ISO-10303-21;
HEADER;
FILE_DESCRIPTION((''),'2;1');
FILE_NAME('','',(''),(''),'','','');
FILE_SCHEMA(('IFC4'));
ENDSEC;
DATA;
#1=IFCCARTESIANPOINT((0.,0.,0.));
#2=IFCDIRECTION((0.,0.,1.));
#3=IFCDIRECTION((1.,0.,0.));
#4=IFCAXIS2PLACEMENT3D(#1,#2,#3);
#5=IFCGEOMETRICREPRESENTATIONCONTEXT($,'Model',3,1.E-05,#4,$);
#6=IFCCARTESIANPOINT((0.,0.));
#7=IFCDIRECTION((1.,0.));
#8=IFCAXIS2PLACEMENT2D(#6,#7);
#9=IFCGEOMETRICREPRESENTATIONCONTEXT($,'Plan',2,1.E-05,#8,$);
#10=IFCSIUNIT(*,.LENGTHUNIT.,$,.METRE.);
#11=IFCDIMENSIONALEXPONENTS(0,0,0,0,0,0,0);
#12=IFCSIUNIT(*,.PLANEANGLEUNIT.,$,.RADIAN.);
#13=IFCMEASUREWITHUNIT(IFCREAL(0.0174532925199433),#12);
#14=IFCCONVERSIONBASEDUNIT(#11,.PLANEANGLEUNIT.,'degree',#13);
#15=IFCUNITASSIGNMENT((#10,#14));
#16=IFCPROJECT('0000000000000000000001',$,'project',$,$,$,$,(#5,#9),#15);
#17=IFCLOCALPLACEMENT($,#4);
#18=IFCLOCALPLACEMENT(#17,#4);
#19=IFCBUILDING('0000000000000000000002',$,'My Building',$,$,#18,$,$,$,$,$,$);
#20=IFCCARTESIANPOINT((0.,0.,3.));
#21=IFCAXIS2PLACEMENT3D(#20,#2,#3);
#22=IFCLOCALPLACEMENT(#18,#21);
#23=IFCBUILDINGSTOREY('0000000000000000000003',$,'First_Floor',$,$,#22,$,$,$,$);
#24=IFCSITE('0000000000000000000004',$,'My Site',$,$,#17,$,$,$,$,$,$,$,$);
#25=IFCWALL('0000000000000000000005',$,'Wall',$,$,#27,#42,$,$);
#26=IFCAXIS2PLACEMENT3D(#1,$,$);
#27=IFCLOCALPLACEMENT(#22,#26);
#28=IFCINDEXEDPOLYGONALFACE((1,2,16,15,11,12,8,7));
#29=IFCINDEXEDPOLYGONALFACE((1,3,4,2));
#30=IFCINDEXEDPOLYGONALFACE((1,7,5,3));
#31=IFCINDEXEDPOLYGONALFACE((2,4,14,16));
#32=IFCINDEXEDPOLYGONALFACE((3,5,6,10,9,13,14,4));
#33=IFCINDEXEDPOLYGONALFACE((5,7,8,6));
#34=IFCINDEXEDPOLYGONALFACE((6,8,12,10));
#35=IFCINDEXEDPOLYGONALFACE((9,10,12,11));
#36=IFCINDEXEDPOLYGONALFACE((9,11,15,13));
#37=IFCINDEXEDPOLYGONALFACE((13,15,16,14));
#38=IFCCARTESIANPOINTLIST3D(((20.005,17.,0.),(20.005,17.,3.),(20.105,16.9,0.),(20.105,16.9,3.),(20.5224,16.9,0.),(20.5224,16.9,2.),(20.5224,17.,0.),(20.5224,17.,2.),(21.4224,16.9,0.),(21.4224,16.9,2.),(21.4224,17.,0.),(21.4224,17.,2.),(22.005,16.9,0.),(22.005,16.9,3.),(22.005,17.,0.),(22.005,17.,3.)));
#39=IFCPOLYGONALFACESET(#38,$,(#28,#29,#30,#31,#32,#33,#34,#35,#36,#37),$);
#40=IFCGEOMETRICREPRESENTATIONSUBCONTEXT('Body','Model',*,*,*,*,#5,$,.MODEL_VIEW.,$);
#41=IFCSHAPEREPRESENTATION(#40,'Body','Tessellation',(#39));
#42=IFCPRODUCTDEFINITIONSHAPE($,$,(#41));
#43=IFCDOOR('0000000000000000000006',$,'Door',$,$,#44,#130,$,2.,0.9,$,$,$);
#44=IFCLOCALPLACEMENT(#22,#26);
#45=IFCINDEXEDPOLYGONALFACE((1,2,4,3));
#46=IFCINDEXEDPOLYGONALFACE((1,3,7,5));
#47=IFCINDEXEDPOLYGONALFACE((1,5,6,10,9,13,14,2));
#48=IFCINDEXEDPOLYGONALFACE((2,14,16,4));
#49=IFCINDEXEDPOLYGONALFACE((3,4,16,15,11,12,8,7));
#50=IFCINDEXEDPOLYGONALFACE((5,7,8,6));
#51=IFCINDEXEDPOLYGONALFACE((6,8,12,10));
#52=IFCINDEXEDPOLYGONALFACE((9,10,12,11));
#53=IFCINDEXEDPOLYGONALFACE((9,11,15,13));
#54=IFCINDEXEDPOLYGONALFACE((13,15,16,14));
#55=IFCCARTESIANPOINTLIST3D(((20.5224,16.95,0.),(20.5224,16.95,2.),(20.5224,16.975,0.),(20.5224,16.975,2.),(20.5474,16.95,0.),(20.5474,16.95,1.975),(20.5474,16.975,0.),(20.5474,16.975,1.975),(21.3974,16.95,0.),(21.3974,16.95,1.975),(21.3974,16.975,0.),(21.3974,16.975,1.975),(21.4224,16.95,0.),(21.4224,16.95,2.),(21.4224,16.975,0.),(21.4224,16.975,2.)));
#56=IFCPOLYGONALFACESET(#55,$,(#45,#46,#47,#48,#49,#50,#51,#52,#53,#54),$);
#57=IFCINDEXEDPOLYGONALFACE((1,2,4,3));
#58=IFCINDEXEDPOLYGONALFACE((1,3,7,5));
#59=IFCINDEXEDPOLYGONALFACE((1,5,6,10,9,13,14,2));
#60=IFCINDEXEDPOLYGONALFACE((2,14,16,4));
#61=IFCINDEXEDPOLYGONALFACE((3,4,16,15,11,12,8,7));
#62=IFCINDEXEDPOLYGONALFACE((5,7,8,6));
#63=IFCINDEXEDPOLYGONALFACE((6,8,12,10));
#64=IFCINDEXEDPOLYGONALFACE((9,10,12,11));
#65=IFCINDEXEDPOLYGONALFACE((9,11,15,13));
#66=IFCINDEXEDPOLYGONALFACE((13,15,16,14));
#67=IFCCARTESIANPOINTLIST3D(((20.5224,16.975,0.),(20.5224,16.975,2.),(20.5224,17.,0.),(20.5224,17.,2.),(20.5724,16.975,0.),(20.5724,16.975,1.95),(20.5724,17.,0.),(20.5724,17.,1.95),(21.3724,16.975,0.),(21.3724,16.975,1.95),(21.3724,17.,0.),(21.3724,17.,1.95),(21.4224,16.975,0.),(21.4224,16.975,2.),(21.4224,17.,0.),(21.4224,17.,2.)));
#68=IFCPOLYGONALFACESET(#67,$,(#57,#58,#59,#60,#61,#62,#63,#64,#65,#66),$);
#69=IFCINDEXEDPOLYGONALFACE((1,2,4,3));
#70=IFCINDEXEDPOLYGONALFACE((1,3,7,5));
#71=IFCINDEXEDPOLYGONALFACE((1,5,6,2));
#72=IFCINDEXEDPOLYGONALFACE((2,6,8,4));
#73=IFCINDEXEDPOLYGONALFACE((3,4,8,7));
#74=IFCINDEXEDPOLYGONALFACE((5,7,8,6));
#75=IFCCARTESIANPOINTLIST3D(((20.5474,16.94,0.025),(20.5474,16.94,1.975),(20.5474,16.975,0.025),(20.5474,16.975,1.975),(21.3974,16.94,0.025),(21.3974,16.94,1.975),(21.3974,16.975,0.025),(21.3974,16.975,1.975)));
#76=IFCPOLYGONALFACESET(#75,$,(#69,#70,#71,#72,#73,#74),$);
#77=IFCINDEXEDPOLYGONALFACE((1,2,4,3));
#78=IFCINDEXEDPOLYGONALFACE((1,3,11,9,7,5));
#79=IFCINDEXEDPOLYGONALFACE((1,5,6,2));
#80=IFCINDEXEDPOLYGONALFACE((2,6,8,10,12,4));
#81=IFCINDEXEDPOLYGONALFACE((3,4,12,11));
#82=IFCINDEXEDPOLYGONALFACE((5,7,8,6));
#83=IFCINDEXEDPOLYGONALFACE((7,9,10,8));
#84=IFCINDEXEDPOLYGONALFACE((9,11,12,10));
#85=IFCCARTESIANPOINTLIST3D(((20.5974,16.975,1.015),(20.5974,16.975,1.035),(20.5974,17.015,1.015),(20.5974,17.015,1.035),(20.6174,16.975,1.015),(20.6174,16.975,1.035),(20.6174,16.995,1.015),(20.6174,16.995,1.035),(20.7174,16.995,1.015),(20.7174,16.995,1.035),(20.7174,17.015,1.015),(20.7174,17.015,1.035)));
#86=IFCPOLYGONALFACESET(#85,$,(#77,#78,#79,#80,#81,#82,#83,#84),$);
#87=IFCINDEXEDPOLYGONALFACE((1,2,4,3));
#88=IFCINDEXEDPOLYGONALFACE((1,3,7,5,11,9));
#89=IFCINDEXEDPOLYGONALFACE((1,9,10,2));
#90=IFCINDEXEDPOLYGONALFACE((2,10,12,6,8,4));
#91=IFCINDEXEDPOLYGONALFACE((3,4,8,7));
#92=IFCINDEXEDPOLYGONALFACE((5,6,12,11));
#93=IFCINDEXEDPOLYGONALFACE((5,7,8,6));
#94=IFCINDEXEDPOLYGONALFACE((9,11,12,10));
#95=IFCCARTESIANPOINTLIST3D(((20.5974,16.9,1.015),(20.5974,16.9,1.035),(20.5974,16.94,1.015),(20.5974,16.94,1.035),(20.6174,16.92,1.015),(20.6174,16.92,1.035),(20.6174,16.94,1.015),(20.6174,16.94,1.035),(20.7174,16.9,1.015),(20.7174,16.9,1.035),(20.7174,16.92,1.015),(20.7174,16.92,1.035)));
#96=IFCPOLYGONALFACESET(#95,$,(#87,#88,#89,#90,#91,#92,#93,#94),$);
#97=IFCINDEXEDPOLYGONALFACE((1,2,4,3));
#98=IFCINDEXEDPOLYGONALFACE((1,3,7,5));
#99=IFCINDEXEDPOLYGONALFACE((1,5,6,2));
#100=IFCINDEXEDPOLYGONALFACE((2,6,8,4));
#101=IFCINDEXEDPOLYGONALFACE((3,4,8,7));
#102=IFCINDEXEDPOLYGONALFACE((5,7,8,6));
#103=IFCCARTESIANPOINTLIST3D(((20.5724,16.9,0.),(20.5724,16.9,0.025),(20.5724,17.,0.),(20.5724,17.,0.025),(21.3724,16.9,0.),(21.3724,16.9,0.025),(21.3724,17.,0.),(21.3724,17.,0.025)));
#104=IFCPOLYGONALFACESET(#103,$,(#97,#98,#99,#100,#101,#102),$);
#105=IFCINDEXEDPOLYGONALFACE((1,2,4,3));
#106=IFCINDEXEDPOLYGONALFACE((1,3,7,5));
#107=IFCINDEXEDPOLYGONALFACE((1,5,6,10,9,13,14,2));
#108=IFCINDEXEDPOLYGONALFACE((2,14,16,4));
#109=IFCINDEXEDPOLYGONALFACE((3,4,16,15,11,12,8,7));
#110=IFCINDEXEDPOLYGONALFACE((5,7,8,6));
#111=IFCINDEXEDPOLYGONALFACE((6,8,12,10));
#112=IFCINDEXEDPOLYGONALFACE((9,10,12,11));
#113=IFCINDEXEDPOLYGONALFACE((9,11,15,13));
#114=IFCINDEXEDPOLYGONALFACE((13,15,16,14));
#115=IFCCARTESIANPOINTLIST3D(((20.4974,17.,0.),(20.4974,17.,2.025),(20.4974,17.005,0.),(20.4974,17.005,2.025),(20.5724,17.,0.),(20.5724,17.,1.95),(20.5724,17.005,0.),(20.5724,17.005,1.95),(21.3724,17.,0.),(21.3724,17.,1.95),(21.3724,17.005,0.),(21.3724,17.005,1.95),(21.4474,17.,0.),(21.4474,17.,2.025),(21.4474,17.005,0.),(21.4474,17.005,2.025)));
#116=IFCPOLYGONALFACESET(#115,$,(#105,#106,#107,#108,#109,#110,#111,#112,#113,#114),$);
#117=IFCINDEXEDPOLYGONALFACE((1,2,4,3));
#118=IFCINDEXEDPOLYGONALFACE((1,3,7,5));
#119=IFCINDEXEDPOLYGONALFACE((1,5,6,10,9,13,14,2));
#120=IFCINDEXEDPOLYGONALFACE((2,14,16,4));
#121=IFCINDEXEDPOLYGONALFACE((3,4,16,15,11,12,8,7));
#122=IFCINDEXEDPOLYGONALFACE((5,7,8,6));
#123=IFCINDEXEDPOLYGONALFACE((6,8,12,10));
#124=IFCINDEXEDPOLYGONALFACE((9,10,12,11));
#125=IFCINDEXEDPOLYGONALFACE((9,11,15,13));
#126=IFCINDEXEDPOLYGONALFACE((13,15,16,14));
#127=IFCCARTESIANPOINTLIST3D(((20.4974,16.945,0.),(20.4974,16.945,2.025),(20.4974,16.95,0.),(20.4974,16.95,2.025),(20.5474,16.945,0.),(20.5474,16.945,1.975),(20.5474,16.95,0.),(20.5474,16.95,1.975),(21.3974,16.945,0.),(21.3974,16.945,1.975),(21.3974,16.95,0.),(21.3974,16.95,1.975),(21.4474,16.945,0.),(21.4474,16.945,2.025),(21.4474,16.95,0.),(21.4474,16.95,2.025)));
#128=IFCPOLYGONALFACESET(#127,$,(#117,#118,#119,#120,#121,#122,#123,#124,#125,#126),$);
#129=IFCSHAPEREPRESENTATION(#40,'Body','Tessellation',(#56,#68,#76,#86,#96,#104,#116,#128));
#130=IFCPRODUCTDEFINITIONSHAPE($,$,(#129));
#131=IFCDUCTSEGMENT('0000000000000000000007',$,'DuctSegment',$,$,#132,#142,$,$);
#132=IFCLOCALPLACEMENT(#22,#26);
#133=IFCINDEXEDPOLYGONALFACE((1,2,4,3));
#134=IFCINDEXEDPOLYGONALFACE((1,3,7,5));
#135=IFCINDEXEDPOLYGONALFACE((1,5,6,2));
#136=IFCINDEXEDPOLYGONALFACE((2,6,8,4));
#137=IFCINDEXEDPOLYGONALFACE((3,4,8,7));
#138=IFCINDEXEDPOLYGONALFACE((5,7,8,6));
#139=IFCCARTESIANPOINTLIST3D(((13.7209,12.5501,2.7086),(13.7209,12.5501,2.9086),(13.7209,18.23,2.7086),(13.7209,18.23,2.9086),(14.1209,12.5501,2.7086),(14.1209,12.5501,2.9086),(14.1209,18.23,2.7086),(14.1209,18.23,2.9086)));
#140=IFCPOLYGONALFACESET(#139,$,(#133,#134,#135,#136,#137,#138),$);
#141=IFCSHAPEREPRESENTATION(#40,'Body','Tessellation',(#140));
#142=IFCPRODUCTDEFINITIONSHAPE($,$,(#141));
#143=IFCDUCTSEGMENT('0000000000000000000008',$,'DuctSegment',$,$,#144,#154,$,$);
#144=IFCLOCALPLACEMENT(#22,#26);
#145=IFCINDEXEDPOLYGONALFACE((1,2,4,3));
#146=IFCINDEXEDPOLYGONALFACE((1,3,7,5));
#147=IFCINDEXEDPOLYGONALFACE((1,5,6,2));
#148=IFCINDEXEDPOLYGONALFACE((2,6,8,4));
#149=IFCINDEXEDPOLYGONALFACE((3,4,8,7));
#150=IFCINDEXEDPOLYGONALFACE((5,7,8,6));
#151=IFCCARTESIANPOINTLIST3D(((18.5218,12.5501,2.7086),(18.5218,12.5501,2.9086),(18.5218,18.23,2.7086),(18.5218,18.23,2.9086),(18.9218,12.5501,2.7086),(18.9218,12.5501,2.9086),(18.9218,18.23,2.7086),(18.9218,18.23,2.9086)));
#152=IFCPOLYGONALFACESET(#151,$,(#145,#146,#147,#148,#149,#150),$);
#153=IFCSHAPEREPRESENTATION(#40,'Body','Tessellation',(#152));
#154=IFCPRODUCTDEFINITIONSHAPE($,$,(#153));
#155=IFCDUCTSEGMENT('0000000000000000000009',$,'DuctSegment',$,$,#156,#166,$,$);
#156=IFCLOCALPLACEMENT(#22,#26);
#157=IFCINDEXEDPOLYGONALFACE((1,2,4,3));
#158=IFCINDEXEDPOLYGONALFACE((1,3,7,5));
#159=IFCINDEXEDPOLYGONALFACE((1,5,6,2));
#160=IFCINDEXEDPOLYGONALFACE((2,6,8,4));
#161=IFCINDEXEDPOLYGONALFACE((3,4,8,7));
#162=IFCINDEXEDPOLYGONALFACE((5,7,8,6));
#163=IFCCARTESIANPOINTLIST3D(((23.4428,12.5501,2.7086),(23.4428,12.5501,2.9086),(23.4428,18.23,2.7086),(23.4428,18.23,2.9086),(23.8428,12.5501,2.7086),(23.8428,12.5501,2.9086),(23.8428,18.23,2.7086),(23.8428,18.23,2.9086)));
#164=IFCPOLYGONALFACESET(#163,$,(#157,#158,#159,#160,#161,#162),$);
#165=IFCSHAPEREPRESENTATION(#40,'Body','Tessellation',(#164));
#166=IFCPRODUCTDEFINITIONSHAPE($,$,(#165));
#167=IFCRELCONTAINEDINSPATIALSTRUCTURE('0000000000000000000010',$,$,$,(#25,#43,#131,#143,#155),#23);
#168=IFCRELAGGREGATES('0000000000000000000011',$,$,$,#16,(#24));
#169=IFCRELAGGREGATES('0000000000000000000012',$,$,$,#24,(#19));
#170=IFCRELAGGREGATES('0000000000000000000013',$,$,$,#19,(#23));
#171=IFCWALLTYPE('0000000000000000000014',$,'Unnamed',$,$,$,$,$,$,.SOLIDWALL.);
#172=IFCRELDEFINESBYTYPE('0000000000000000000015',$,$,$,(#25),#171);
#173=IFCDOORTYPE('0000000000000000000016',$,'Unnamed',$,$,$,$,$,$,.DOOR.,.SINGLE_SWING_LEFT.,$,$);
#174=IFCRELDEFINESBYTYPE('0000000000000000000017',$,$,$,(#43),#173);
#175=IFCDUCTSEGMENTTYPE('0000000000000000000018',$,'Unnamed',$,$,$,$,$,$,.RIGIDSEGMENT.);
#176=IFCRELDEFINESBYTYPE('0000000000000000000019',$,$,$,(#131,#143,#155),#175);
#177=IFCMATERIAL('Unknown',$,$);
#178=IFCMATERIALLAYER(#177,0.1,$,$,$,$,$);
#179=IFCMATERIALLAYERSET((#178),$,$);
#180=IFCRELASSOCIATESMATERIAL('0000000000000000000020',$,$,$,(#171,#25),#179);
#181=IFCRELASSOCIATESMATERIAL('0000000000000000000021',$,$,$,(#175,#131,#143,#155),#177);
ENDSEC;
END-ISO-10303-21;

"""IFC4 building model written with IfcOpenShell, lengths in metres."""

from ifc_helpers import new_model, entity, si_unit, converted_unit, frame, origin_with_axes, origin_2d_with_axis, place, context, subcontext, project, spatial, line, indexed_curve, rectangle, outline, extrude, shape, source, transform, mapped, material, layer, layer_set, layer_usage, material_profile, profile_set, profile_usage, type_object, type_shapes, element, fill, save


model = new_model("IFC4")

# Units and contexts
model_context = context("Model", 3, precision=1e-05, world=origin_with_axes())
plan_context = context("Plan", 2, precision=1e-05, world=origin_2d_with_axis())
body_context_1 = subcontext(model_context, "Body", "Model", "MODEL_VIEW")
body_context_2 = subcontext(plan_context, "Body", "Plan", "PLAN_VIEW")
ifc_project = project(units=[si_unit("LENGTHUNIT", "METRE"), converted_unit("PLANEANGLEUNIT", "degree", entity("IfcReal", 0.0174532925199433), si_unit("PLANEANGLEUNIT", "RADIAN"), dimensions=[0, 0, 0, 0, 0, 0, 0])], contexts=[model_context, plan_context])

# Site, building, storey
site_placement = place(None, origin_with_axes())
site = spatial("IfcSite", under=ifc_project, at=site_placement, Name="My Site")
building_placement = place(site_placement, origin_with_axes())
building = spatial("IfcBuilding", under=site, at=building_placement, Name="My Building")
storey_placement = place(building_placement, frame((0.0, 0.0, 3.0), z_axis=(0.0, 0.0, 1.0), x_axis=(1.0, 0.0, 0.0)))
storey = spatial("IfcBuildingStorey", under=building, at=storey_placement, Name="First_Floor")

# Shared definitions
ifc_material = material(Name="Unknown")
ifc_layer = layer(ifc_material, 0.1)
ifc_layer_set = layer_set([ifc_layer])
wall_type = type_object("IfcWallType", Name="Unnamed", PredefinedType="SOLIDWALL", material=ifc_layer_set)
shared_shape_1 = source(origin_with_axes(), body_context_1, "Body", "SweptSolid", [
    extrude(outline(indexed_curve([(0.0, 0.0), (0.9, 0.0), (0.9, 2.0), (0.0, 2.0)], segments=[line(1, 2, 3, 4, 1)])), frame((0.0, -0.6, 0.0), z_axis=(0.0, -1.0, 0.0), x_axis=(1.0, 0.0, 0.0)), (0.0, 0.0, -1.0), 1.2),
])
door_type = type_object("IfcDoorType", Name="Unnamed", OperationType="SINGLE_SWING_LEFT", PredefinedType="DOOR")
shared_shape_2 = source(origin_with_axes(), body_context_1, "Body", "SweptSolid", [
    extrude(outline(indexed_curve([(0.0, 0.0), (0.0, 2.0), (0.9, 2.0), (0.9, 0.0), (0.875, 0.0), (0.875, 1.975), (0.025, 1.975), (0.025, 0.0)], segments=[line(1, 2, 3, 4, 5, 6, 7, 8, 1)])), frame((0.0, 0.025, 0.0), z_axis=(0.0, -1.0, 0.0), x_axis=(1.0, 0.0, 0.0)), (0.0, 0.0, -1.0), 0.025),
    extrude(outline(indexed_curve([(0.0, 0.0), (0.0, 2.0), (0.9, 2.0), (0.9, 0.0), (0.85, 0.0), (0.85, 1.95), (0.05, 1.95), (0.05, 0.0)], segments=[line(1, 2, 3, 4, 5, 6, 7, 8, 1)])), frame((0.0, 0.0, 0.0), z_axis=(0.0, -1.0, 0.0), x_axis=(1.0, 0.0, 0.0)), (0.0, 0.0, -1.0), 0.025),
    extrude(outline(indexed_curve([(0.0, 0.0), (0.85, 0.0), (0.85, 0.035), (0.0, 0.035)], segments=[line(1, 2, 3, 4, 1)])), frame((0.025, 0.025, 0.025), z_axis=(0.0, 0.0, 1.0), x_axis=(1.0, 0.0, 0.0)), (0.0, 0.0, 1.0), 1.95),
    extrude(outline(indexed_curve([(0.0, 0.0), (0.0, -0.04), (-0.12, -0.04), (-0.12, -0.02), (-0.02, -0.02), (-0.02, 0.0)], segments=[line(1, 2, 3, 4, 5, 6, 1)])), frame((0.825, 0.025, 1.015), z_axis=(0.0, 0.0, 1.0), x_axis=(1.0, 0.0, 0.0)), (0.0, 0.0, 1.0), 0.02),
    extrude(outline(indexed_curve([(0.0, 0.0), (0.0, 0.04), (-0.12, 0.04), (-0.12, 0.02), (-0.02, 0.02), (-0.02, 0.0)], segments=[line(1, 2, 3, 4, 5, 6, 1)])), frame((0.825, 0.06, 1.015), z_axis=(0.0, 0.0, 1.0), x_axis=(1.0, 0.0, 0.0)), (0.0, 0.0, 1.0), 0.02),
    extrude(outline(indexed_curve([(0.0, 0.0), (0.8, 0.0), (0.8, 0.1), (0.0, 0.1)], segments=[line(1, 2, 3, 4, 1)])), frame((0.05, 0.0, 0.0), z_axis=(0.0, 0.0, 1.0), x_axis=(1.0, 0.0, 0.0)), (0.0, 0.0, 1.0), 0.025),
    extrude(outline(indexed_curve([(0.0, 0.0), (0.0, 2.025), (0.95, 2.025), (0.95, 0.0), (0.875, 0.0), (0.875, 1.95), (0.075, 1.95), (0.075, 0.0)], segments=[line(1, 2, 3, 4, 5, 6, 7, 8, 1)])), frame((-0.025, -0.005, 0.0), z_axis=(0.0, -1.0, 0.0), x_axis=(1.0, 0.0, 0.0)), (0.0, 0.0, -1.0), 0.005),
    extrude(outline(indexed_curve([(0.0, 0.0), (0.0, 2.025), (0.95, 2.025), (0.95, 0.0), (0.9, 0.0), (0.9, 1.975), (0.05, 1.975), (0.05, 0.0)], segments=[line(1, 2, 3, 4, 5, 6, 7, 8, 1)])), frame((-0.025, 0.05, 0.0), z_axis=(0.0, -1.0, 0.0), x_axis=(1.0, 0.0, 0.0)), (0.0, 0.0, -1.0), 0.005),
])
shared_shape_3 = source(origin_with_axes(), body_context_2, "Body", "Curve2D", [
    entity("IfcIndexedPolyCurve", entity("IfcCartesianPointList2D", [[0.0, 0.0], [0.0, 0.05], [0.025, 0.05], [0.025, 0.025], [0.05, 0.025], [0.05, 0.0]]), [entity("IfcLineIndex", [1, 2, 3, 4, 5, 6, 1])]),
    entity("IfcIndexedPolyCurve", entity("IfcCartesianPointList2D", [[0.9, 0.0], [0.9, 0.05], [0.875, 0.05], [0.875, 0.025], [0.85, 0.025], [0.85, 0.0]]), [entity("IfcLineIndex", [1, 2, 3, 4, 5, 6, 1])]),
    entity("IfcTrimmedCurve", entity("IfcEllipse", entity("IfcAxis2Placement2D", entity("IfcCartesianPoint", [0.06, 0.05]), entity("IfcDirection", [1.0, 0.0])), 0.815, 0.85), [entity("IfcCartesianPoint", [0.875, 0.05])], [entity("IfcCartesianPoint", [0.06, 0.9])], True, "CARTESIAN"),
    entity("IfcIndexedPolyCurve", entity("IfcCartesianPointList2D", [[0.025, 0.05], [0.06, 0.05], [0.06, 0.9], [0.025, 0.9]]), [entity("IfcLineIndex", [1, 2, 3, 4, 1])]),
])
type_shapes(door_type, [shared_shape_2, shared_shape_3])

# Wall, opening, door
ifc_layer_usage_1 = layer_usage(ifc_layer_set, "AXIS2", "POSITIVE", 0.0)
wall_1_placement = place(storey_placement, frame((22.005, 17.0, 0.0), z_axis=(0.0, 0.0, 1.0), x_axis=(-1.0, 0.0, 0.0)))
wall_1 = element("IfcWall", 1, at=wall_1_placement, inside=storey, type_object=wall_type, material=ifc_layer_usage_1, Name="Wall", context=body_context_1, shape_type="SweptSolid", body=[
    extrude(outline(indexed_curve([(0.0, 0.0), (0.0, 0.1), (1.9, 0.1), (2.0, 0.0)], segments=[line(1, 2, 3, 4, 1)])), origin_with_axes(), (0.0, 0.0, 1.0), 3.0),
])
opening_1_placement = place(wall_1_placement, frame((0.5826, 0.0, 0.0), z_axis=(0.0, 0.0, 1.0), x_axis=(1.0, 0.0, 0.0)))
opening_1 = element("IfcOpeningElement", 2, at=opening_1_placement, cuts=wall_1, PredefinedType="OPENING", context=body_context_1, shape_type="MappedRepresentation", body=[
    mapped(shared_shape_1, transform((0.0, 0.0, 0.0), x_axis=(1.0, 0.0, 0.0), y_axis=(0.0, 1.0, 0.0), z_axis=(0.0, 0.0, 1.0), scale=1.0)),
])
door_1_placement = place(opening_1_placement, origin_with_axes())
door_1 = element("IfcDoor", 3, at=door_1_placement, inside=storey, type_object=door_type, Name="Door", OverallHeight=2.0, OverallWidth=0.9, shapes=[
    shape(body_context_1, "Body", "MappedRepresentation", [mapped(shared_shape_2, transform((0.0, 0.0, 0.0), x_axis=(1.0, 0.0, 0.0), y_axis=(0.0, 1.0, 0.0), z_axis=(0.0, 0.0, 1.0), scale=1.0))]),
    shape(body_context_2, "Body", "MappedRepresentation", [mapped(shared_shape_3, transform((0.0, 0.0, 0.0), x_axis=(1.0, 0.0, 0.0), y_axis=(0.0, 1.0, 0.0), z_axis=(0.0, 0.0, 1.0), scale=1.0))]),
])
fill(opening_1, door_1)

# Duct segments
ifc_material_profile_1 = material_profile(ifc_material, rectangle(XDim=0.4, YDim=0.2))
ifc_profile_set_1 = profile_set([ifc_material_profile_1])
ifc_profile_usage_1 = profile_usage(ifc_profile_set_1, cardinal=5)
duct_segment_type = type_object("IfcDuctSegmentType", Name="Unnamed", PredefinedType="RIGIDSEGMENT", material=ifc_profile_set_1)
duct_segment_1_placement = place(storey_placement, frame((13.9209, 12.5501, 2.8086), z_axis=(0.0, 1.0, 0.0), x_axis=(-1.0, 0.0, 0.0)))
element("IfcDuctSegment", 4, at=duct_segment_1_placement, inside=storey, type_object=duct_segment_type, material=ifc_profile_usage_1, Name="DuctSegment", context=body_context_1, shape_type="SweptSolid", body=[
    extrude(rectangle(XDim=0.4, YDim=0.2), origin_with_axes(), (0.0, 0.0, 1.0), 5.6799),
])
ifc_profile_usage_2 = profile_usage(ifc_profile_set_1, cardinal=5)
duct_segment_2_placement = place(storey_placement, frame((18.7218, 12.5501, 2.8086), z_axis=(0.0, 1.0, 0.0), x_axis=(-1.0, 0.0, 0.0)))
element("IfcDuctSegment", 5, at=duct_segment_2_placement, inside=storey, type_object=duct_segment_type, material=ifc_profile_usage_2, Name="DuctSegment", context=body_context_1, shape_type="SweptSolid", body=[
    extrude(rectangle(XDim=0.4, YDim=0.2), origin_with_axes(), (0.0, 0.0, 1.0), 5.6799),
])
ifc_profile_usage_3 = profile_usage(ifc_profile_set_1, cardinal=5)
duct_segment_3_placement = place(storey_placement, frame((23.6428, 12.5501, 2.8086), z_axis=(0.0, 1.0, 0.0), x_axis=(-1.0, 0.0, 0.0)))
element("IfcDuctSegment", 6, at=duct_segment_3_placement, inside=storey, type_object=duct_segment_type, material=ifc_profile_usage_3, Name="DuctSegment", context=body_context_1, shape_type="SweptSolid", body=[
    extrude(rectangle(XDim=0.4, YDim=0.2), origin_with_axes(), (0.0, 0.0, 1.0), 5.6799),
])

save(model, "model.ifc")
